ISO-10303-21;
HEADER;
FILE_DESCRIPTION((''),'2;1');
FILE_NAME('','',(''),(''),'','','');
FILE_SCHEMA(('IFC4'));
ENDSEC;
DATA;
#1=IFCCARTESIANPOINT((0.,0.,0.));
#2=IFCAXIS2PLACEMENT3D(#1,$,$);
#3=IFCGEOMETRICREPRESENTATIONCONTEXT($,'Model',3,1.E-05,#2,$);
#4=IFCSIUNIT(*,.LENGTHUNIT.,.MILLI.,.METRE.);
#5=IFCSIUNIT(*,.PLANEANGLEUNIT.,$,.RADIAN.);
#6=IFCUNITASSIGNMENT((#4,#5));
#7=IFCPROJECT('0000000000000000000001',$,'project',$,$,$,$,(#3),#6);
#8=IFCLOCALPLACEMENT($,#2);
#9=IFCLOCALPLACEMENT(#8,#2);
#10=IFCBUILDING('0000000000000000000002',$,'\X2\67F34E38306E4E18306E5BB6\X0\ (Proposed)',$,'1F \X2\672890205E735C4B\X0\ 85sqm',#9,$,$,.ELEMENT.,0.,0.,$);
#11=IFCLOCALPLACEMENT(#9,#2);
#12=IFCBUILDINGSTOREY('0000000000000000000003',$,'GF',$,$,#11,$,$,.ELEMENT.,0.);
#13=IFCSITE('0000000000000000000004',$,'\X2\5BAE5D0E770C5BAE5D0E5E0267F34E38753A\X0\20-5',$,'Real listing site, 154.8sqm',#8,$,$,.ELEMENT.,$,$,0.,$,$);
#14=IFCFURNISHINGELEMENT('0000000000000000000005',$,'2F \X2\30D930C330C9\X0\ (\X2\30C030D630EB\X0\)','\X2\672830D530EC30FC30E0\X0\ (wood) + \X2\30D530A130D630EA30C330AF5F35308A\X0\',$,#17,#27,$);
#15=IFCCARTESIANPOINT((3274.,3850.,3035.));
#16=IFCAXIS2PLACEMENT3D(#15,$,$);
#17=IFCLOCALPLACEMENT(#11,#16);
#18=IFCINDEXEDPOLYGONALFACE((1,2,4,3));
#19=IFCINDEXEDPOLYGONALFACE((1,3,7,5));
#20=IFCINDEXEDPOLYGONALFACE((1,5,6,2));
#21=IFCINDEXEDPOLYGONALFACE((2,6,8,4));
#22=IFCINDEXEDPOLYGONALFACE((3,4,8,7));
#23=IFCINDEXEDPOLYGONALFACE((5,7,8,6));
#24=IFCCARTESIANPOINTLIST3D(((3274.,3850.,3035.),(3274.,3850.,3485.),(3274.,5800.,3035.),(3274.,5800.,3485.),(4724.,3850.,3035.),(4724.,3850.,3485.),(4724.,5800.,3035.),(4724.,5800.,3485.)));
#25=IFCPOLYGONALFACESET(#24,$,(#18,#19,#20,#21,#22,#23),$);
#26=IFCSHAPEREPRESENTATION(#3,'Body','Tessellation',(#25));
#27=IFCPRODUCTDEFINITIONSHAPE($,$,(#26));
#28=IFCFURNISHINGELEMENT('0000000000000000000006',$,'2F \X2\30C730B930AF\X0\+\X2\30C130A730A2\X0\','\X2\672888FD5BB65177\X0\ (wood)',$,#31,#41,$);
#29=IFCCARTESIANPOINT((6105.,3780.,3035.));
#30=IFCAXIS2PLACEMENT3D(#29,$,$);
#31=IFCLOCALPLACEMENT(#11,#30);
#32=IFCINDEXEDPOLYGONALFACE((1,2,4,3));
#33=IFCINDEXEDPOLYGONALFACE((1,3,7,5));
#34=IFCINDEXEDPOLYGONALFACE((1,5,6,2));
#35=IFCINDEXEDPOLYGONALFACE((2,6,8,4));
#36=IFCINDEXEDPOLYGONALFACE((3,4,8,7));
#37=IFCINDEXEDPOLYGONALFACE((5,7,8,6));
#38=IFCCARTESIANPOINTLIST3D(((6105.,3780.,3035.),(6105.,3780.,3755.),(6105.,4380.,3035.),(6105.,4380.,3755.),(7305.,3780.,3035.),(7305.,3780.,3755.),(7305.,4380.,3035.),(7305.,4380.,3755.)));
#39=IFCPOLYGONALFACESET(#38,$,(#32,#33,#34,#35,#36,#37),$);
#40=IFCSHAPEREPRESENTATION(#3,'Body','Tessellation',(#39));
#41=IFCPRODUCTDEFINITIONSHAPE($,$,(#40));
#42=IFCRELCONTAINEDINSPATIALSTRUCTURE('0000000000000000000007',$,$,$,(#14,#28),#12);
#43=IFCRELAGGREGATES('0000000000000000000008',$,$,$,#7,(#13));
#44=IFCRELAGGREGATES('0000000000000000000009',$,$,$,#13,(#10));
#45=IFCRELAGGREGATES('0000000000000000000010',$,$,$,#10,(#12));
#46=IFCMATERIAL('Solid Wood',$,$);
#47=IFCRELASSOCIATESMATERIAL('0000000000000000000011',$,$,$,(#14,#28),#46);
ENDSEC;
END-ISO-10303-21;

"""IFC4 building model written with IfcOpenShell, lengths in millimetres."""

from ifc_helpers import new_model, si_unit, frame, frame_2d, origin, place, context, project, spatial, rectangle, extrude, material, element, save


model = new_model("IFC4")

# Units and contexts
model_context = context("Model", 3, precision=1e-05, world=origin())
ifc_project = project(units=[si_unit("LENGTHUNIT", "METRE", prefix="MILLI"), si_unit("PLANEANGLEUNIT", "RADIAN")], contexts=[model_context])

# Site, building, storey
site_placement = place(None, origin())
site = spatial("IfcSite", under=ifc_project, at=site_placement, Name="宮崎県宮崎市柳丸町20-5", ObjectType="Real listing site, 154.8sqm", CompositionType="ELEMENT", RefElevation=0.0)
building_placement = place(site_placement, origin())
building = spatial("IfcBuilding", under=site, at=building_placement, Name="柳丸の丘の家 (Proposed)", ObjectType="1F 木造平屋 85sqm", CompositionType="ELEMENT", ElevationOfRefHeight=0.0, ElevationOfTerrain=0.0)
storey_placement = place(building_placement, origin())
storey = spatial("IfcBuildingStorey", under=building, at=storey_placement, Name="GF", CompositionType="ELEMENT", Elevation=0.0)

# Shared definitions
ifc_material_1 = material(Name="Solid Wood")

# Furnishing elements
furnishing_1_placement = place(storey_placement, frame((3274.0, 3850.0, 3035.0)))
element("IfcFurnishingElement", 1, at=furnishing_1_placement, inside=storey, material=ifc_material_1, Name="2F ベッド (ダブル)", Description="木フレーム (wood) + ファブリック張り", context=model_context, shape_type="SweptSolid", body=[
    extrude(rectangle(XDim=1450.0, YDim=1950.0, at=frame_2d((725.0, 975.0))), frame((3274.0, 3850.0, 3035.0)), (0.0, 0.0, 1.0), 450.0),
])
furnishing_2_placement = place(storey_placement, frame((6105.0, 3780.0, 3035.0)))
element("IfcFurnishingElement", 2, at=furnishing_2_placement, inside=storey, material=ifc_material_1, Name="2F デスク+チェア", Description="木製家具 (wood)", context=model_context, shape_type="SweptSolid", body=[
    extrude(rectangle(XDim=1200.0, YDim=600.0, at=frame_2d((600.0, 300.0))), frame((6105.0, 3780.0, 3035.0)), (0.0, 0.0, 1.0), 720.0),
])

save(model, "model.ifc")
